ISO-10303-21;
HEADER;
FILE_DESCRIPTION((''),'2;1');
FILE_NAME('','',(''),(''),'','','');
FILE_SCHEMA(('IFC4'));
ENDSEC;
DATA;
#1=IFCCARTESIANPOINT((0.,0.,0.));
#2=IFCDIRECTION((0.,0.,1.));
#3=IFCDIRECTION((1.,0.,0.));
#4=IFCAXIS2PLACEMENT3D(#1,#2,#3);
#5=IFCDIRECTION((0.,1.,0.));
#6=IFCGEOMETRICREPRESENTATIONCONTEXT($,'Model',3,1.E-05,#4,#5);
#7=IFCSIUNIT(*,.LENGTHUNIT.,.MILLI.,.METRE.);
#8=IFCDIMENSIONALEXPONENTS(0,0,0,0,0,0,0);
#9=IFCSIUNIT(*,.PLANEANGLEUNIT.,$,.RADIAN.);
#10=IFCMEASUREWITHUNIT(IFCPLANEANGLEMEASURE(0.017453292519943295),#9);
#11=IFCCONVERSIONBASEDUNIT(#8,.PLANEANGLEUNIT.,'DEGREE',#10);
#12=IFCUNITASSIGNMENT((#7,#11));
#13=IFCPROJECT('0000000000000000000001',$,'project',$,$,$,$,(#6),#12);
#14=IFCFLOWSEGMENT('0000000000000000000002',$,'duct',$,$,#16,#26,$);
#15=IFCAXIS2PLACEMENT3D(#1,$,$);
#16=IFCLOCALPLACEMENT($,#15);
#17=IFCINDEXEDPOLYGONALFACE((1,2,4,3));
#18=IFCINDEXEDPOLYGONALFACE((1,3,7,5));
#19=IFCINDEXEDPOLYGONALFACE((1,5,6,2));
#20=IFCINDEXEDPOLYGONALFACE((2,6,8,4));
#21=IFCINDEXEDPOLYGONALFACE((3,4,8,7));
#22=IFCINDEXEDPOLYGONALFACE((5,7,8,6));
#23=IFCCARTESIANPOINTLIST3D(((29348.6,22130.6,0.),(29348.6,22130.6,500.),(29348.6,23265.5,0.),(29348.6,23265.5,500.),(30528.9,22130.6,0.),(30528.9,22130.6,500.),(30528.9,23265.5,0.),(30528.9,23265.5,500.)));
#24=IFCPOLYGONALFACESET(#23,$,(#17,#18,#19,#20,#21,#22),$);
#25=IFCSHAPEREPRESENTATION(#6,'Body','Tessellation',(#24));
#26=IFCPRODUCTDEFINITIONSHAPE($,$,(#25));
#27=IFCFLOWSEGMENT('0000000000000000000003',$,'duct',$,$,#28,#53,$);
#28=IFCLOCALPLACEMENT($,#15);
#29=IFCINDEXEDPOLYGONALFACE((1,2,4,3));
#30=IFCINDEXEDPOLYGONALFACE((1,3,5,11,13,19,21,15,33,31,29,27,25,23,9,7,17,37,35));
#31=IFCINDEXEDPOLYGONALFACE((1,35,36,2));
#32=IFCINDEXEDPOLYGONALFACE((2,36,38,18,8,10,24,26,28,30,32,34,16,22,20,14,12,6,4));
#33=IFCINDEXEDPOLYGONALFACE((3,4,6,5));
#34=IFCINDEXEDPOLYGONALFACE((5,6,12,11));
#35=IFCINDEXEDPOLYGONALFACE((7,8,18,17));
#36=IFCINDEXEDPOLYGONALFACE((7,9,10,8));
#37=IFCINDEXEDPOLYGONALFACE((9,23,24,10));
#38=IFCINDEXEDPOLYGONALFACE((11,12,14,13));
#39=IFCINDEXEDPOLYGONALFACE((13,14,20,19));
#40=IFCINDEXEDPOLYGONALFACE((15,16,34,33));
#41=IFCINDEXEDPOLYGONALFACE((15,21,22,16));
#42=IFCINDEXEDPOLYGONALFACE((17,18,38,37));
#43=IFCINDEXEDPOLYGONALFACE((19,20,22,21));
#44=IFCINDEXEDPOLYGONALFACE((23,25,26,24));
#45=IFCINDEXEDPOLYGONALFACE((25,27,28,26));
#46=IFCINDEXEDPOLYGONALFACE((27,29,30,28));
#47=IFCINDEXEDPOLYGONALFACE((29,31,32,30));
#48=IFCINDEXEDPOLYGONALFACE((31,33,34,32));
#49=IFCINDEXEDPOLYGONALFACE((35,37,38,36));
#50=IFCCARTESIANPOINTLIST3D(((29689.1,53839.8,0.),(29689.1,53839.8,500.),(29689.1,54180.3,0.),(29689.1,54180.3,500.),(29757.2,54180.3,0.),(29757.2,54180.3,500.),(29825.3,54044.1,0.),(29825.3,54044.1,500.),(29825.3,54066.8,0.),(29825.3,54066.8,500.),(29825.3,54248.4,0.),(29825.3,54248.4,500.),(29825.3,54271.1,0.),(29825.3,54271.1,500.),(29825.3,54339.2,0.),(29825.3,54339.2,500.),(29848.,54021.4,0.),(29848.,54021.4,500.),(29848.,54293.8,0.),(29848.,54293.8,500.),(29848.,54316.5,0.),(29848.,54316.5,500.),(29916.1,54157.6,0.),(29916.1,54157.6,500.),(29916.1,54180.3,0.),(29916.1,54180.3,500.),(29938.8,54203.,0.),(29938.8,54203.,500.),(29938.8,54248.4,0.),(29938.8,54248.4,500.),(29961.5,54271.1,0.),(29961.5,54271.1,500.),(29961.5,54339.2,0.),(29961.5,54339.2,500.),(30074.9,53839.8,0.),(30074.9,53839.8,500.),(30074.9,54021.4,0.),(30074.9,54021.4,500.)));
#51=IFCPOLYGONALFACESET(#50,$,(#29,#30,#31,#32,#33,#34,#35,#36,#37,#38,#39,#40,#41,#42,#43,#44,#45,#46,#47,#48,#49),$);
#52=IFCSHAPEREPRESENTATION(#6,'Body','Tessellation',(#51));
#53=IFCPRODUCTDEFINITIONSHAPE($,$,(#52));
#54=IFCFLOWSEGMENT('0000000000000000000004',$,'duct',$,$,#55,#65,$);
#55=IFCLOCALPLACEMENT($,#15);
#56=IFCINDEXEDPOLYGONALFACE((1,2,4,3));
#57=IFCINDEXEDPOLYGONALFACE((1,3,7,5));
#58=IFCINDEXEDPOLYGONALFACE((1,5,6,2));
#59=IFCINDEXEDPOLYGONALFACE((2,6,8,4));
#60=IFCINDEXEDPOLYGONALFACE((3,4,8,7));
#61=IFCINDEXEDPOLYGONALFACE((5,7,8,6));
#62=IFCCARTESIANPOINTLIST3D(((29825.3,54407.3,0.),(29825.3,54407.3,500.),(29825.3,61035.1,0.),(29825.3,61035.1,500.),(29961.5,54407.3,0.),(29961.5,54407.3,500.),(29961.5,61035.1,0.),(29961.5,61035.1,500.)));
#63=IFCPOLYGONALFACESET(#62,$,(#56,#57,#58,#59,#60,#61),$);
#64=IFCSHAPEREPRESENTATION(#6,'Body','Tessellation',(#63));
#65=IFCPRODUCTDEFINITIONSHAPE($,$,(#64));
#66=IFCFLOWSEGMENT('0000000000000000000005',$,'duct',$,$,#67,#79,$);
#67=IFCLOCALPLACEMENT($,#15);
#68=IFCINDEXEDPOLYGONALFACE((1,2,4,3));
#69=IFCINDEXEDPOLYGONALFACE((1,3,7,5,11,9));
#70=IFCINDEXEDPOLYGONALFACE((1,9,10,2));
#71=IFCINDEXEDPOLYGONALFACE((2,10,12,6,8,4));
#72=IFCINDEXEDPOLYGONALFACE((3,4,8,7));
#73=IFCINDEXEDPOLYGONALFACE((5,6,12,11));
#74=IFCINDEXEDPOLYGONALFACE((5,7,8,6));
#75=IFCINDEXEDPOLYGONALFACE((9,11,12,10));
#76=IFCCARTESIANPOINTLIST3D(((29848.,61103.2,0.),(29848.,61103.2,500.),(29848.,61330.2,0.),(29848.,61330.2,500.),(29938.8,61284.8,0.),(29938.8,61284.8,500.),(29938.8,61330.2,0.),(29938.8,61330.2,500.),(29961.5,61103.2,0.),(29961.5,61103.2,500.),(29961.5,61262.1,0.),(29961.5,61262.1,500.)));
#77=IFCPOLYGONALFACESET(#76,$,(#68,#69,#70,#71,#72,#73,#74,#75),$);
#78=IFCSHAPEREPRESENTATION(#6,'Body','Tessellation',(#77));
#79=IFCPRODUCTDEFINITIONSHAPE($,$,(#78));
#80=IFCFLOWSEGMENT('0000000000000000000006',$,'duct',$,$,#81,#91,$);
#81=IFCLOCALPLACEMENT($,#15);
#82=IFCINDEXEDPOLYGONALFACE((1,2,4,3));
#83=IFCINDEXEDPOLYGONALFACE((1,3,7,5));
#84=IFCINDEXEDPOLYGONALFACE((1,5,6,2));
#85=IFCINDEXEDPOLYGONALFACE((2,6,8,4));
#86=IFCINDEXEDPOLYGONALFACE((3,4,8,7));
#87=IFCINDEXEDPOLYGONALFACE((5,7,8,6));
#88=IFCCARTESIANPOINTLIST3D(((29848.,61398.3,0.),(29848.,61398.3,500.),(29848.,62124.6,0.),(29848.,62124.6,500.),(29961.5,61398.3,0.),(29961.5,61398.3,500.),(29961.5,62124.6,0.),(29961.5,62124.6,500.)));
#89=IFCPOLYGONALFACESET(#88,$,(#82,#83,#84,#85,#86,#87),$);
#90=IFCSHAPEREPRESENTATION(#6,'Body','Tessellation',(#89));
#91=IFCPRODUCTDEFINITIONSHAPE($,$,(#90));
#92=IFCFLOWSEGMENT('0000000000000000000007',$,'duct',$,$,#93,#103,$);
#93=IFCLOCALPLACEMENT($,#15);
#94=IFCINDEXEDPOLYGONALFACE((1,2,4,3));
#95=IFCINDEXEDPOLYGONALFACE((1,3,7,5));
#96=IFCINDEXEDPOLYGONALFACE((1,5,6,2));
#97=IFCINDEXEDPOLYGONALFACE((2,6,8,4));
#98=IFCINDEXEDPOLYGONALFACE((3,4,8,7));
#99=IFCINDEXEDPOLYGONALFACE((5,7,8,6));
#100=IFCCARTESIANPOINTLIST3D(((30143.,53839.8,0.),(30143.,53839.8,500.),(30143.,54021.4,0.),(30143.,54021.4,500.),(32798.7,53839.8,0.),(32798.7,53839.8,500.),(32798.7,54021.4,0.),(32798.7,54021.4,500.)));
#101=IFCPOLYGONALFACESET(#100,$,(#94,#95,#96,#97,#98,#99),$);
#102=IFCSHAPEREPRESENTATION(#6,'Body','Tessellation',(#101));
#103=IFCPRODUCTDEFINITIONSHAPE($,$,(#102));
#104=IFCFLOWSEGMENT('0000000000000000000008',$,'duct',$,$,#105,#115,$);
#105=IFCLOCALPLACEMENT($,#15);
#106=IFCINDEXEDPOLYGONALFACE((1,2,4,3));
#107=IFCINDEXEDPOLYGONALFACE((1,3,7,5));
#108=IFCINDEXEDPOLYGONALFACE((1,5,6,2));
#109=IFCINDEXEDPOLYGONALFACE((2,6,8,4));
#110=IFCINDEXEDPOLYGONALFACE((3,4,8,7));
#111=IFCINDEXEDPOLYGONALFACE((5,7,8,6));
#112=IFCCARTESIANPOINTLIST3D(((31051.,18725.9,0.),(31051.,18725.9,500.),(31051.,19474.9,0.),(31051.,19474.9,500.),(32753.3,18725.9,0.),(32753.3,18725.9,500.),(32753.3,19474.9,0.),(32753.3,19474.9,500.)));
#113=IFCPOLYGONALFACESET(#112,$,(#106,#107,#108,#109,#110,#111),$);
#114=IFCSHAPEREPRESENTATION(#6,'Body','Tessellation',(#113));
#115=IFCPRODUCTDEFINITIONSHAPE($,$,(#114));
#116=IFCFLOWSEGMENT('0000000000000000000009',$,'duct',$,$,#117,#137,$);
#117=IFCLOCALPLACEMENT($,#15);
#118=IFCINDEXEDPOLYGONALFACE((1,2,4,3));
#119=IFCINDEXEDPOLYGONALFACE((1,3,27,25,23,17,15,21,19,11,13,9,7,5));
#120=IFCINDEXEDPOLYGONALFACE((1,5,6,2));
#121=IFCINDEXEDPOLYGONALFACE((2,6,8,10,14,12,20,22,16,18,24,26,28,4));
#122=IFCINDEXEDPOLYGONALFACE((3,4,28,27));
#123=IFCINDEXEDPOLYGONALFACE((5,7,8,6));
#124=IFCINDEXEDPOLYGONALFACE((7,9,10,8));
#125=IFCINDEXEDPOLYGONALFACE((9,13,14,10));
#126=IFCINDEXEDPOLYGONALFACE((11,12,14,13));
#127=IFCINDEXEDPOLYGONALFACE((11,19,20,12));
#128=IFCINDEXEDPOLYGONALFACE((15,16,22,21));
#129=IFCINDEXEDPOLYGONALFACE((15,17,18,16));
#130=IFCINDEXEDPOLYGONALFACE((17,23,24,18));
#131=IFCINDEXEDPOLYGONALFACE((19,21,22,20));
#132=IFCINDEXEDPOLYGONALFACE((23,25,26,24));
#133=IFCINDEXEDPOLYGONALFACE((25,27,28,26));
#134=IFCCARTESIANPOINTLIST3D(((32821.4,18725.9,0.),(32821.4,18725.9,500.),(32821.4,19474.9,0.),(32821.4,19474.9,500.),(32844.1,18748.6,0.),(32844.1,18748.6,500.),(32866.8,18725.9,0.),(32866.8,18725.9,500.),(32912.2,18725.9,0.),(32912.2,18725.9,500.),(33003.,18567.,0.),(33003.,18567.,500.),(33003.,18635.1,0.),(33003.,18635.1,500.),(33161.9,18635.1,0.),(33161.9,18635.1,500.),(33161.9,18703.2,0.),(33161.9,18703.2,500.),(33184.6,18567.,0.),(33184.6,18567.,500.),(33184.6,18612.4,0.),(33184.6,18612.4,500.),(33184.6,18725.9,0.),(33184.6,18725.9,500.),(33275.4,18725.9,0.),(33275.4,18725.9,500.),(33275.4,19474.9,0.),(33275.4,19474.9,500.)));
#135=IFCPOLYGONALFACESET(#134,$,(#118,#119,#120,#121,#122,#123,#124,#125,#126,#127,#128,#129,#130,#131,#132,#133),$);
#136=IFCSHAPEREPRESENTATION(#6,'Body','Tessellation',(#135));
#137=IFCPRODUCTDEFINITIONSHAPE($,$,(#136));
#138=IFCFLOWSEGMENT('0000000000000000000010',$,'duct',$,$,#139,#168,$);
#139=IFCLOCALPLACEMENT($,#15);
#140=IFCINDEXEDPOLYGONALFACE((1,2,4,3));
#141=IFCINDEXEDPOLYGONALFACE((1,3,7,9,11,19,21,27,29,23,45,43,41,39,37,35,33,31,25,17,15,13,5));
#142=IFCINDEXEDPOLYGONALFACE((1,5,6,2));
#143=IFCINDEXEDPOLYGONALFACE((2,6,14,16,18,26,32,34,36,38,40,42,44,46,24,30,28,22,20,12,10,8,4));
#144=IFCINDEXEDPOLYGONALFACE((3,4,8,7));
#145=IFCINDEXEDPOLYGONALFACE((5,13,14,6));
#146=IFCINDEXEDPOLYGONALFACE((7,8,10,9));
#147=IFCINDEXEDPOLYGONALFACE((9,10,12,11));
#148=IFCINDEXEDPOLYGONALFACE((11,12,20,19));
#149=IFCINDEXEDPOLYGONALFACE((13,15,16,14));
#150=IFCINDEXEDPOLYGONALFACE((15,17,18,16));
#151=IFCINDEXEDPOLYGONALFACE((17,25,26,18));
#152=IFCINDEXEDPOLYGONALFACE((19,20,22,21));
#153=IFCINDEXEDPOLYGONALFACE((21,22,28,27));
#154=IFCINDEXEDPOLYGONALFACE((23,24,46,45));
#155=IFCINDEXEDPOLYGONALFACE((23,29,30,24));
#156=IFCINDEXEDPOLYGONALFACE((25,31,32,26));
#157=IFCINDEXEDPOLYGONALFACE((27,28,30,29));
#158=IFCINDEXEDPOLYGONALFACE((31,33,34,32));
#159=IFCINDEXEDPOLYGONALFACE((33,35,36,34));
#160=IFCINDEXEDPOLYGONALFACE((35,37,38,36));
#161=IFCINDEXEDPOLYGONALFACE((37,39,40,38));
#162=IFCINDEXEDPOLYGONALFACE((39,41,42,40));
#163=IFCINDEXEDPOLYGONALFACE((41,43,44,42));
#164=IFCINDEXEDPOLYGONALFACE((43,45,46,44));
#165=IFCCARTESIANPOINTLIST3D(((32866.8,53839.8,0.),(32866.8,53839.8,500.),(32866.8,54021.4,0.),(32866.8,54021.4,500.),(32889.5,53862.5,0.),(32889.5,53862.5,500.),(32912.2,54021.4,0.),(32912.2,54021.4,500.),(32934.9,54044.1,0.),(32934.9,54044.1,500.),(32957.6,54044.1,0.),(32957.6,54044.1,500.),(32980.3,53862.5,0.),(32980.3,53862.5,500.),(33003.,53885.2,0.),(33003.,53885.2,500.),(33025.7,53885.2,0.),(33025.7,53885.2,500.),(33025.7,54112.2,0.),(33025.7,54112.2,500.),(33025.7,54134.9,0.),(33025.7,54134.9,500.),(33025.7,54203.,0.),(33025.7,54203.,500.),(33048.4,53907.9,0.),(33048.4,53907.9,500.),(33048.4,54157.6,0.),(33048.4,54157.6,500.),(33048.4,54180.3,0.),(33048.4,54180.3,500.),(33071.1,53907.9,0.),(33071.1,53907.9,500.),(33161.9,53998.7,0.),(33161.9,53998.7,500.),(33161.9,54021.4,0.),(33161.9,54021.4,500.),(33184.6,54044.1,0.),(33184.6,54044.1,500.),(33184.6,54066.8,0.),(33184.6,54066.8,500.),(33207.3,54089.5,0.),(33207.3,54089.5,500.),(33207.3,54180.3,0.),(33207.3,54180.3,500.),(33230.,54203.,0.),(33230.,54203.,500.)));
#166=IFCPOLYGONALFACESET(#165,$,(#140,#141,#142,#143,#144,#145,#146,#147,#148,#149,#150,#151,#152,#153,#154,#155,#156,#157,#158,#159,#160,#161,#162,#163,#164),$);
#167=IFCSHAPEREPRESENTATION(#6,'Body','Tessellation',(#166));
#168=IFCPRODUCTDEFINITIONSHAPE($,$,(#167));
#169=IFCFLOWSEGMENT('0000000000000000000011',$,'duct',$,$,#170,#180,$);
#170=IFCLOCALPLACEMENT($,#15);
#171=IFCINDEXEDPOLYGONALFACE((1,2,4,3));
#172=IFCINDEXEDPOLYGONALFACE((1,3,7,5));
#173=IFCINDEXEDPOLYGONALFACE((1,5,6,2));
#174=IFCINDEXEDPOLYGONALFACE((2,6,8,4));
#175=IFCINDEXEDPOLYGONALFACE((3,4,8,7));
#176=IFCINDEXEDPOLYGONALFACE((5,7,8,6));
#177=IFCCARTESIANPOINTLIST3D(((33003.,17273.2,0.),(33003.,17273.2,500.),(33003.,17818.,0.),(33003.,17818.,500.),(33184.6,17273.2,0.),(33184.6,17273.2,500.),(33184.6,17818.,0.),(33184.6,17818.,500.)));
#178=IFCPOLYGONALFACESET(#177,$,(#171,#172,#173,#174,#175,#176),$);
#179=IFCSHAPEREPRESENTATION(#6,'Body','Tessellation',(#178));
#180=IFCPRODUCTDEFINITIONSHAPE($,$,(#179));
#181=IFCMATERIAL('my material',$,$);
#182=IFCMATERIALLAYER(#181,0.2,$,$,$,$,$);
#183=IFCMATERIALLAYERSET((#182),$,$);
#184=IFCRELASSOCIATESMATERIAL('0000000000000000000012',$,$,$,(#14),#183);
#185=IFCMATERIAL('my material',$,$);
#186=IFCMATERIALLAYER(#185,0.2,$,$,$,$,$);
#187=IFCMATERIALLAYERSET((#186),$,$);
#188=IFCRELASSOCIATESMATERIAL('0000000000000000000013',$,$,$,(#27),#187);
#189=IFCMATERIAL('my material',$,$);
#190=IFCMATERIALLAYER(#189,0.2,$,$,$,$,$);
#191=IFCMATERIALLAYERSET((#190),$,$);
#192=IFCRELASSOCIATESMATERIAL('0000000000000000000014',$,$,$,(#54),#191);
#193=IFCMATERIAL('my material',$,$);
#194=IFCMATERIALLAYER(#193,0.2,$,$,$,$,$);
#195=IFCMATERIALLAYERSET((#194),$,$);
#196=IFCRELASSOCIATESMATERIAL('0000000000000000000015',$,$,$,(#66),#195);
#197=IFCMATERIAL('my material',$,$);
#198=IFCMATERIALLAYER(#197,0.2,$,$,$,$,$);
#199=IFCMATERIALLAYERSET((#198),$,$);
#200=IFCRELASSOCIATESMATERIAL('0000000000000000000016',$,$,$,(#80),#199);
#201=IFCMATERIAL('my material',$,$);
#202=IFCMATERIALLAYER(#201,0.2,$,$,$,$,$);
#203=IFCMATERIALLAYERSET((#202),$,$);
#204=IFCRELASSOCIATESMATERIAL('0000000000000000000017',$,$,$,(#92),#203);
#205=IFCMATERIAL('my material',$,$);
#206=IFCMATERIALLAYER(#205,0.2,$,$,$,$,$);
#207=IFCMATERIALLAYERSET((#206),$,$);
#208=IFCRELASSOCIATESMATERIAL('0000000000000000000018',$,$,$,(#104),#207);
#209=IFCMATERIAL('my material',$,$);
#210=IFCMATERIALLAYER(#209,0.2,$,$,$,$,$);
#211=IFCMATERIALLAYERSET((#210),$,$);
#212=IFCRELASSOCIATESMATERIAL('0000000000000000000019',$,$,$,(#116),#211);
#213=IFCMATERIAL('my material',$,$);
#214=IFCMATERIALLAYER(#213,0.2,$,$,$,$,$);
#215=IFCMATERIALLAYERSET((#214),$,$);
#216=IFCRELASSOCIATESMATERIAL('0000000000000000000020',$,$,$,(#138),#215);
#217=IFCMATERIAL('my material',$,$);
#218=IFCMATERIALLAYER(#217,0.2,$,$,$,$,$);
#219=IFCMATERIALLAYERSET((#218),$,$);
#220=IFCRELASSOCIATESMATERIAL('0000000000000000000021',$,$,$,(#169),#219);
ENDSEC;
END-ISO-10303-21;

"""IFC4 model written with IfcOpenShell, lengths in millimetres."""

from ifc_helpers import new_model, entity, si_unit, converted_unit, direction, origin_with_axes, place, context, project, polyline, outline, extrude, material, layer, layer_set, layer_usage, element, save


model = new_model("IFC4")

# Units and contexts
model_context = context("Model", 3, precision=1e-05, world=origin_with_axes(), true_north=direction((0.0, 1.0, 0.0)))
ifc_project = project(units=[si_unit("LENGTHUNIT", "METRE", prefix="MILLI"), converted_unit("PLANEANGLEUNIT", "DEGREE", entity("IfcPlaneAngleMeasure", 0.017453292519943295), si_unit("PLANEANGLEUNIT", "RADIAN"), dimensions=[0, 0, 0, 0, 0, 0, 0])], contexts=[model_context])

# Flow segments
ifc_material_1 = material(Name="my material")
ifc_layer_1 = layer(ifc_material_1, 0.2)
ifc_layer_set_1 = layer_set([ifc_layer_1])
ifc_layer_usage_1 = layer_usage(ifc_layer_set_1, "AXIS2", "POSITIVE", -0.1)
flow_segment_1_placement = place(None, origin_with_axes())
element("IfcFlowSegment", 1, at=flow_segment_1_placement, material=ifc_layer_usage_1, Name="duct", context=model_context, shape_type="SweptSolid", body=[
    extrude(outline(polyline([(29348.6, 22130.6), (30528.9, 22130.6), (30528.9, 23265.5), (29348.6, 23265.5), (29348.6, 22130.6)])), origin_with_axes(), (0.0, 0.0, 1.0), 500.0),
])
ifc_material_2 = material(Name="my material")
ifc_layer_2 = layer(ifc_material_2, 0.2)
ifc_layer_set_2 = layer_set([ifc_layer_2])
ifc_layer_usage_2 = layer_usage(ifc_layer_set_2, "AXIS2", "POSITIVE", -0.1)
flow_segment_2_placement = place(None, origin_with_axes())
element("IfcFlowSegment", 2, at=flow_segment_2_placement, material=ifc_layer_usage_2, Name="duct", context=model_context, shape_type="SweptSolid", body=[
    extrude(outline(polyline([(29689.1, 53839.8), (30074.9, 53839.8), (30074.9, 54021.4), (29848.0, 54021.4), (29825.3, 54044.1), (29825.3, 54066.8), (29916.1, 54157.6), (29916.1, 54180.3), (29938.8, 54203.0), (29938.8, 54248.4), (29961.5, 54271.1), (29961.5, 54339.2), (29825.3, 54339.2), (29848.0, 54316.5), (29848.0, 54293.8), (29825.3, 54271.1), (29825.3, 54248.4), (29757.2, 54180.3), (29689.1, 54180.3), (29689.1, 53839.8)])), origin_with_axes(), (0.0, 0.0, 1.0), 500.0),
])
ifc_material_3 = material(Name="my material")
ifc_layer_3 = layer(ifc_material_3, 0.2)
ifc_layer_set_3 = layer_set([ifc_layer_3])
ifc_layer_usage_3 = layer_usage(ifc_layer_set_3, "AXIS2", "POSITIVE", -0.1)
flow_segment_3_placement = place(None, origin_with_axes())
element("IfcFlowSegment", 3, at=flow_segment_3_placement, material=ifc_layer_usage_3, Name="duct", context=model_context, shape_type="SweptSolid", body=[
    extrude(outline(polyline([(29825.3, 54407.3), (29961.5, 54407.3), (29961.5, 61035.1), (29825.3, 61035.1), (29825.3, 54407.3)])), origin_with_axes(), (0.0, 0.0, 1.0), 500.0),
])
ifc_material_4 = material(Name="my material")
ifc_layer_4 = layer(ifc_material_4, 0.2)
ifc_layer_set_4 = layer_set([ifc_layer_4])
ifc_layer_usage_4 = layer_usage(ifc_layer_set_4, "AXIS2", "POSITIVE", -0.1)
flow_segment_4_placement = place(None, origin_with_axes())
element("IfcFlowSegment", 4, at=flow_segment_4_placement, material=ifc_layer_usage_4, Name="duct", context=model_context, shape_type="SweptSolid", body=[
    extrude(outline(polyline([(29848.0, 61103.2), (29961.5, 61103.2), (29961.5, 61262.1), (29938.8, 61284.8), (29938.8, 61330.2), (29848.0, 61330.2), (29848.0, 61103.2)])), origin_with_axes(), (0.0, 0.0, 1.0), 500.0),
])
ifc_material_5 = material(Name="my material")
ifc_layer_5 = layer(ifc_material_5, 0.2)
ifc_layer_set_5 = layer_set([ifc_layer_5])
ifc_layer_usage_5 = layer_usage(ifc_layer_set_5, "AXIS2", "POSITIVE", -0.1)
flow_segment_5_placement = place(None, origin_with_axes())
element("IfcFlowSegment", 5, at=flow_segment_5_placement, material=ifc_layer_usage_5, Name="duct", context=model_context, shape_type="SweptSolid", body=[
    extrude(outline(polyline([(29848.0, 61398.3), (29961.5, 61398.3), (29961.5, 62124.6), (29848.0, 62124.6), (29848.0, 61398.3)])), origin_with_axes(), (0.0, 0.0, 1.0), 500.0),
])
ifc_material_6 = material(Name="my material")
ifc_layer_6 = layer(ifc_material_6, 0.2)
ifc_layer_set_6 = layer_set([ifc_layer_6])
ifc_layer_usage_6 = layer_usage(ifc_layer_set_6, "AXIS2", "POSITIVE", -0.1)
flow_segment_6_placement = place(None, origin_with_axes())
element("IfcFlowSegment", 6, at=flow_segment_6_placement, material=ifc_layer_usage_6, Name="duct", context=model_context, shape_type="SweptSolid", body=[
    extrude(outline(polyline([(30143.0, 53839.8), (32798.7, 53839.8), (32798.7, 54021.4), (30143.0, 54021.4), (30143.0, 53839.8)])), origin_with_axes(), (0.0, 0.0, 1.0), 500.0),
])
ifc_material_7 = material(Name="my material")
ifc_layer_7 = layer(ifc_material_7, 0.2)
ifc_layer_set_7 = layer_set([ifc_layer_7])
ifc_layer_usage_7 = layer_usage(ifc_layer_set_7, "AXIS2", "POSITIVE", -0.1)
flow_segment_7_placement = place(None, origin_with_axes())
element("IfcFlowSegment", 7, at=flow_segment_7_placement, material=ifc_layer_usage_7, Name="duct", context=model_context, shape_type="SweptSolid", body=[
    extrude(outline(polyline([(31051.0, 18725.9), (32753.3, 18725.9), (32753.3, 19474.9), (31051.0, 19474.9), (31051.0, 18725.9)])), origin_with_axes(), (0.0, 0.0, 1.0), 500.0),
])
ifc_material_8 = material(Name="my material")
ifc_layer_8 = layer(ifc_material_8, 0.2)
ifc_layer_set_8 = layer_set([ifc_layer_8])
ifc_layer_usage_8 = layer_usage(ifc_layer_set_8, "AXIS2", "POSITIVE", -0.1)
flow_segment_8_placement = place(None, origin_with_axes())
element("IfcFlowSegment", 8, at=flow_segment_8_placement, material=ifc_layer_usage_8, Name="duct", context=model_context, shape_type="SweptSolid", body=[
    extrude(outline(polyline([(32821.4, 18725.9), (32844.1, 18748.6), (32866.8, 18725.9), (32912.2, 18725.9), (33003.0, 18635.1), (33003.0, 18567.0), (33184.6, 18567.0), (33184.6, 18612.4), (33161.9, 18635.1), (33161.9, 18703.2), (33184.6, 18725.9), (33275.4, 18725.9), (33275.4, 19474.9), (32821.4, 19474.9), (32821.4, 18725.9)])), origin_with_axes(), (0.0, 0.0, 1.0), 500.0),
])
ifc_material_9 = material(Name="my material")
ifc_layer_9 = layer(ifc_material_9, 0.2)
ifc_layer_set_9 = layer_set([ifc_layer_9])
ifc_layer_usage_9 = layer_usage(ifc_layer_set_9, "AXIS2", "POSITIVE", -0.1)
flow_segment_9_placement = place(None, origin_with_axes())
element("IfcFlowSegment", 9, at=flow_segment_9_placement, material=ifc_layer_usage_9, Name="duct", context=model_context, shape_type="SweptSolid", body=[
    extrude(outline(polyline([(32866.8, 53839.8), (32889.5, 53862.5), (32980.3, 53862.5), (33003.0, 53885.2), (33025.7, 53885.2), (33048.4, 53907.9), (33071.1, 53907.9), (33161.9, 53998.7), (33161.9, 54021.4), (33184.6, 54044.1), (33184.6, 54066.8), (33207.3, 54089.5), (33207.3, 54180.3), (33230.0, 54203.0), (33025.7, 54203.0), (33048.4, 54180.3), (33048.4, 54157.6), (33025.7, 54134.9), (33025.7, 54112.2), (32957.6, 54044.1), (32934.9, 54044.1), (32912.2, 54021.4), (32866.8, 54021.4), (32866.8, 53839.8)])), origin_with_axes(), (0.0, 0.0, 1.0), 500.0),
])
ifc_material_10 = material(Name="my material")
ifc_layer_10 = layer(ifc_material_10, 0.2)
ifc_layer_set_10 = layer_set([ifc_layer_10])
ifc_layer_usage_10 = layer_usage(ifc_layer_set_10, "AXIS2", "POSITIVE", -0.1)
flow_segment_10_placement = place(None, origin_with_axes())
element("IfcFlowSegment", 10, at=flow_segment_10_placement, material=ifc_layer_usage_10, Name="duct", context=model_context, shape_type="SweptSolid", body=[
    extrude(outline(polyline([(33003.0, 17273.2), (33184.6, 17273.2), (33184.6, 17818.0), (33003.0, 17818.0), (33003.0, 17273.2)])), origin_with_axes(), (0.0, 0.0, 1.0), 500.0),
])

save(model, "model.ifc")
